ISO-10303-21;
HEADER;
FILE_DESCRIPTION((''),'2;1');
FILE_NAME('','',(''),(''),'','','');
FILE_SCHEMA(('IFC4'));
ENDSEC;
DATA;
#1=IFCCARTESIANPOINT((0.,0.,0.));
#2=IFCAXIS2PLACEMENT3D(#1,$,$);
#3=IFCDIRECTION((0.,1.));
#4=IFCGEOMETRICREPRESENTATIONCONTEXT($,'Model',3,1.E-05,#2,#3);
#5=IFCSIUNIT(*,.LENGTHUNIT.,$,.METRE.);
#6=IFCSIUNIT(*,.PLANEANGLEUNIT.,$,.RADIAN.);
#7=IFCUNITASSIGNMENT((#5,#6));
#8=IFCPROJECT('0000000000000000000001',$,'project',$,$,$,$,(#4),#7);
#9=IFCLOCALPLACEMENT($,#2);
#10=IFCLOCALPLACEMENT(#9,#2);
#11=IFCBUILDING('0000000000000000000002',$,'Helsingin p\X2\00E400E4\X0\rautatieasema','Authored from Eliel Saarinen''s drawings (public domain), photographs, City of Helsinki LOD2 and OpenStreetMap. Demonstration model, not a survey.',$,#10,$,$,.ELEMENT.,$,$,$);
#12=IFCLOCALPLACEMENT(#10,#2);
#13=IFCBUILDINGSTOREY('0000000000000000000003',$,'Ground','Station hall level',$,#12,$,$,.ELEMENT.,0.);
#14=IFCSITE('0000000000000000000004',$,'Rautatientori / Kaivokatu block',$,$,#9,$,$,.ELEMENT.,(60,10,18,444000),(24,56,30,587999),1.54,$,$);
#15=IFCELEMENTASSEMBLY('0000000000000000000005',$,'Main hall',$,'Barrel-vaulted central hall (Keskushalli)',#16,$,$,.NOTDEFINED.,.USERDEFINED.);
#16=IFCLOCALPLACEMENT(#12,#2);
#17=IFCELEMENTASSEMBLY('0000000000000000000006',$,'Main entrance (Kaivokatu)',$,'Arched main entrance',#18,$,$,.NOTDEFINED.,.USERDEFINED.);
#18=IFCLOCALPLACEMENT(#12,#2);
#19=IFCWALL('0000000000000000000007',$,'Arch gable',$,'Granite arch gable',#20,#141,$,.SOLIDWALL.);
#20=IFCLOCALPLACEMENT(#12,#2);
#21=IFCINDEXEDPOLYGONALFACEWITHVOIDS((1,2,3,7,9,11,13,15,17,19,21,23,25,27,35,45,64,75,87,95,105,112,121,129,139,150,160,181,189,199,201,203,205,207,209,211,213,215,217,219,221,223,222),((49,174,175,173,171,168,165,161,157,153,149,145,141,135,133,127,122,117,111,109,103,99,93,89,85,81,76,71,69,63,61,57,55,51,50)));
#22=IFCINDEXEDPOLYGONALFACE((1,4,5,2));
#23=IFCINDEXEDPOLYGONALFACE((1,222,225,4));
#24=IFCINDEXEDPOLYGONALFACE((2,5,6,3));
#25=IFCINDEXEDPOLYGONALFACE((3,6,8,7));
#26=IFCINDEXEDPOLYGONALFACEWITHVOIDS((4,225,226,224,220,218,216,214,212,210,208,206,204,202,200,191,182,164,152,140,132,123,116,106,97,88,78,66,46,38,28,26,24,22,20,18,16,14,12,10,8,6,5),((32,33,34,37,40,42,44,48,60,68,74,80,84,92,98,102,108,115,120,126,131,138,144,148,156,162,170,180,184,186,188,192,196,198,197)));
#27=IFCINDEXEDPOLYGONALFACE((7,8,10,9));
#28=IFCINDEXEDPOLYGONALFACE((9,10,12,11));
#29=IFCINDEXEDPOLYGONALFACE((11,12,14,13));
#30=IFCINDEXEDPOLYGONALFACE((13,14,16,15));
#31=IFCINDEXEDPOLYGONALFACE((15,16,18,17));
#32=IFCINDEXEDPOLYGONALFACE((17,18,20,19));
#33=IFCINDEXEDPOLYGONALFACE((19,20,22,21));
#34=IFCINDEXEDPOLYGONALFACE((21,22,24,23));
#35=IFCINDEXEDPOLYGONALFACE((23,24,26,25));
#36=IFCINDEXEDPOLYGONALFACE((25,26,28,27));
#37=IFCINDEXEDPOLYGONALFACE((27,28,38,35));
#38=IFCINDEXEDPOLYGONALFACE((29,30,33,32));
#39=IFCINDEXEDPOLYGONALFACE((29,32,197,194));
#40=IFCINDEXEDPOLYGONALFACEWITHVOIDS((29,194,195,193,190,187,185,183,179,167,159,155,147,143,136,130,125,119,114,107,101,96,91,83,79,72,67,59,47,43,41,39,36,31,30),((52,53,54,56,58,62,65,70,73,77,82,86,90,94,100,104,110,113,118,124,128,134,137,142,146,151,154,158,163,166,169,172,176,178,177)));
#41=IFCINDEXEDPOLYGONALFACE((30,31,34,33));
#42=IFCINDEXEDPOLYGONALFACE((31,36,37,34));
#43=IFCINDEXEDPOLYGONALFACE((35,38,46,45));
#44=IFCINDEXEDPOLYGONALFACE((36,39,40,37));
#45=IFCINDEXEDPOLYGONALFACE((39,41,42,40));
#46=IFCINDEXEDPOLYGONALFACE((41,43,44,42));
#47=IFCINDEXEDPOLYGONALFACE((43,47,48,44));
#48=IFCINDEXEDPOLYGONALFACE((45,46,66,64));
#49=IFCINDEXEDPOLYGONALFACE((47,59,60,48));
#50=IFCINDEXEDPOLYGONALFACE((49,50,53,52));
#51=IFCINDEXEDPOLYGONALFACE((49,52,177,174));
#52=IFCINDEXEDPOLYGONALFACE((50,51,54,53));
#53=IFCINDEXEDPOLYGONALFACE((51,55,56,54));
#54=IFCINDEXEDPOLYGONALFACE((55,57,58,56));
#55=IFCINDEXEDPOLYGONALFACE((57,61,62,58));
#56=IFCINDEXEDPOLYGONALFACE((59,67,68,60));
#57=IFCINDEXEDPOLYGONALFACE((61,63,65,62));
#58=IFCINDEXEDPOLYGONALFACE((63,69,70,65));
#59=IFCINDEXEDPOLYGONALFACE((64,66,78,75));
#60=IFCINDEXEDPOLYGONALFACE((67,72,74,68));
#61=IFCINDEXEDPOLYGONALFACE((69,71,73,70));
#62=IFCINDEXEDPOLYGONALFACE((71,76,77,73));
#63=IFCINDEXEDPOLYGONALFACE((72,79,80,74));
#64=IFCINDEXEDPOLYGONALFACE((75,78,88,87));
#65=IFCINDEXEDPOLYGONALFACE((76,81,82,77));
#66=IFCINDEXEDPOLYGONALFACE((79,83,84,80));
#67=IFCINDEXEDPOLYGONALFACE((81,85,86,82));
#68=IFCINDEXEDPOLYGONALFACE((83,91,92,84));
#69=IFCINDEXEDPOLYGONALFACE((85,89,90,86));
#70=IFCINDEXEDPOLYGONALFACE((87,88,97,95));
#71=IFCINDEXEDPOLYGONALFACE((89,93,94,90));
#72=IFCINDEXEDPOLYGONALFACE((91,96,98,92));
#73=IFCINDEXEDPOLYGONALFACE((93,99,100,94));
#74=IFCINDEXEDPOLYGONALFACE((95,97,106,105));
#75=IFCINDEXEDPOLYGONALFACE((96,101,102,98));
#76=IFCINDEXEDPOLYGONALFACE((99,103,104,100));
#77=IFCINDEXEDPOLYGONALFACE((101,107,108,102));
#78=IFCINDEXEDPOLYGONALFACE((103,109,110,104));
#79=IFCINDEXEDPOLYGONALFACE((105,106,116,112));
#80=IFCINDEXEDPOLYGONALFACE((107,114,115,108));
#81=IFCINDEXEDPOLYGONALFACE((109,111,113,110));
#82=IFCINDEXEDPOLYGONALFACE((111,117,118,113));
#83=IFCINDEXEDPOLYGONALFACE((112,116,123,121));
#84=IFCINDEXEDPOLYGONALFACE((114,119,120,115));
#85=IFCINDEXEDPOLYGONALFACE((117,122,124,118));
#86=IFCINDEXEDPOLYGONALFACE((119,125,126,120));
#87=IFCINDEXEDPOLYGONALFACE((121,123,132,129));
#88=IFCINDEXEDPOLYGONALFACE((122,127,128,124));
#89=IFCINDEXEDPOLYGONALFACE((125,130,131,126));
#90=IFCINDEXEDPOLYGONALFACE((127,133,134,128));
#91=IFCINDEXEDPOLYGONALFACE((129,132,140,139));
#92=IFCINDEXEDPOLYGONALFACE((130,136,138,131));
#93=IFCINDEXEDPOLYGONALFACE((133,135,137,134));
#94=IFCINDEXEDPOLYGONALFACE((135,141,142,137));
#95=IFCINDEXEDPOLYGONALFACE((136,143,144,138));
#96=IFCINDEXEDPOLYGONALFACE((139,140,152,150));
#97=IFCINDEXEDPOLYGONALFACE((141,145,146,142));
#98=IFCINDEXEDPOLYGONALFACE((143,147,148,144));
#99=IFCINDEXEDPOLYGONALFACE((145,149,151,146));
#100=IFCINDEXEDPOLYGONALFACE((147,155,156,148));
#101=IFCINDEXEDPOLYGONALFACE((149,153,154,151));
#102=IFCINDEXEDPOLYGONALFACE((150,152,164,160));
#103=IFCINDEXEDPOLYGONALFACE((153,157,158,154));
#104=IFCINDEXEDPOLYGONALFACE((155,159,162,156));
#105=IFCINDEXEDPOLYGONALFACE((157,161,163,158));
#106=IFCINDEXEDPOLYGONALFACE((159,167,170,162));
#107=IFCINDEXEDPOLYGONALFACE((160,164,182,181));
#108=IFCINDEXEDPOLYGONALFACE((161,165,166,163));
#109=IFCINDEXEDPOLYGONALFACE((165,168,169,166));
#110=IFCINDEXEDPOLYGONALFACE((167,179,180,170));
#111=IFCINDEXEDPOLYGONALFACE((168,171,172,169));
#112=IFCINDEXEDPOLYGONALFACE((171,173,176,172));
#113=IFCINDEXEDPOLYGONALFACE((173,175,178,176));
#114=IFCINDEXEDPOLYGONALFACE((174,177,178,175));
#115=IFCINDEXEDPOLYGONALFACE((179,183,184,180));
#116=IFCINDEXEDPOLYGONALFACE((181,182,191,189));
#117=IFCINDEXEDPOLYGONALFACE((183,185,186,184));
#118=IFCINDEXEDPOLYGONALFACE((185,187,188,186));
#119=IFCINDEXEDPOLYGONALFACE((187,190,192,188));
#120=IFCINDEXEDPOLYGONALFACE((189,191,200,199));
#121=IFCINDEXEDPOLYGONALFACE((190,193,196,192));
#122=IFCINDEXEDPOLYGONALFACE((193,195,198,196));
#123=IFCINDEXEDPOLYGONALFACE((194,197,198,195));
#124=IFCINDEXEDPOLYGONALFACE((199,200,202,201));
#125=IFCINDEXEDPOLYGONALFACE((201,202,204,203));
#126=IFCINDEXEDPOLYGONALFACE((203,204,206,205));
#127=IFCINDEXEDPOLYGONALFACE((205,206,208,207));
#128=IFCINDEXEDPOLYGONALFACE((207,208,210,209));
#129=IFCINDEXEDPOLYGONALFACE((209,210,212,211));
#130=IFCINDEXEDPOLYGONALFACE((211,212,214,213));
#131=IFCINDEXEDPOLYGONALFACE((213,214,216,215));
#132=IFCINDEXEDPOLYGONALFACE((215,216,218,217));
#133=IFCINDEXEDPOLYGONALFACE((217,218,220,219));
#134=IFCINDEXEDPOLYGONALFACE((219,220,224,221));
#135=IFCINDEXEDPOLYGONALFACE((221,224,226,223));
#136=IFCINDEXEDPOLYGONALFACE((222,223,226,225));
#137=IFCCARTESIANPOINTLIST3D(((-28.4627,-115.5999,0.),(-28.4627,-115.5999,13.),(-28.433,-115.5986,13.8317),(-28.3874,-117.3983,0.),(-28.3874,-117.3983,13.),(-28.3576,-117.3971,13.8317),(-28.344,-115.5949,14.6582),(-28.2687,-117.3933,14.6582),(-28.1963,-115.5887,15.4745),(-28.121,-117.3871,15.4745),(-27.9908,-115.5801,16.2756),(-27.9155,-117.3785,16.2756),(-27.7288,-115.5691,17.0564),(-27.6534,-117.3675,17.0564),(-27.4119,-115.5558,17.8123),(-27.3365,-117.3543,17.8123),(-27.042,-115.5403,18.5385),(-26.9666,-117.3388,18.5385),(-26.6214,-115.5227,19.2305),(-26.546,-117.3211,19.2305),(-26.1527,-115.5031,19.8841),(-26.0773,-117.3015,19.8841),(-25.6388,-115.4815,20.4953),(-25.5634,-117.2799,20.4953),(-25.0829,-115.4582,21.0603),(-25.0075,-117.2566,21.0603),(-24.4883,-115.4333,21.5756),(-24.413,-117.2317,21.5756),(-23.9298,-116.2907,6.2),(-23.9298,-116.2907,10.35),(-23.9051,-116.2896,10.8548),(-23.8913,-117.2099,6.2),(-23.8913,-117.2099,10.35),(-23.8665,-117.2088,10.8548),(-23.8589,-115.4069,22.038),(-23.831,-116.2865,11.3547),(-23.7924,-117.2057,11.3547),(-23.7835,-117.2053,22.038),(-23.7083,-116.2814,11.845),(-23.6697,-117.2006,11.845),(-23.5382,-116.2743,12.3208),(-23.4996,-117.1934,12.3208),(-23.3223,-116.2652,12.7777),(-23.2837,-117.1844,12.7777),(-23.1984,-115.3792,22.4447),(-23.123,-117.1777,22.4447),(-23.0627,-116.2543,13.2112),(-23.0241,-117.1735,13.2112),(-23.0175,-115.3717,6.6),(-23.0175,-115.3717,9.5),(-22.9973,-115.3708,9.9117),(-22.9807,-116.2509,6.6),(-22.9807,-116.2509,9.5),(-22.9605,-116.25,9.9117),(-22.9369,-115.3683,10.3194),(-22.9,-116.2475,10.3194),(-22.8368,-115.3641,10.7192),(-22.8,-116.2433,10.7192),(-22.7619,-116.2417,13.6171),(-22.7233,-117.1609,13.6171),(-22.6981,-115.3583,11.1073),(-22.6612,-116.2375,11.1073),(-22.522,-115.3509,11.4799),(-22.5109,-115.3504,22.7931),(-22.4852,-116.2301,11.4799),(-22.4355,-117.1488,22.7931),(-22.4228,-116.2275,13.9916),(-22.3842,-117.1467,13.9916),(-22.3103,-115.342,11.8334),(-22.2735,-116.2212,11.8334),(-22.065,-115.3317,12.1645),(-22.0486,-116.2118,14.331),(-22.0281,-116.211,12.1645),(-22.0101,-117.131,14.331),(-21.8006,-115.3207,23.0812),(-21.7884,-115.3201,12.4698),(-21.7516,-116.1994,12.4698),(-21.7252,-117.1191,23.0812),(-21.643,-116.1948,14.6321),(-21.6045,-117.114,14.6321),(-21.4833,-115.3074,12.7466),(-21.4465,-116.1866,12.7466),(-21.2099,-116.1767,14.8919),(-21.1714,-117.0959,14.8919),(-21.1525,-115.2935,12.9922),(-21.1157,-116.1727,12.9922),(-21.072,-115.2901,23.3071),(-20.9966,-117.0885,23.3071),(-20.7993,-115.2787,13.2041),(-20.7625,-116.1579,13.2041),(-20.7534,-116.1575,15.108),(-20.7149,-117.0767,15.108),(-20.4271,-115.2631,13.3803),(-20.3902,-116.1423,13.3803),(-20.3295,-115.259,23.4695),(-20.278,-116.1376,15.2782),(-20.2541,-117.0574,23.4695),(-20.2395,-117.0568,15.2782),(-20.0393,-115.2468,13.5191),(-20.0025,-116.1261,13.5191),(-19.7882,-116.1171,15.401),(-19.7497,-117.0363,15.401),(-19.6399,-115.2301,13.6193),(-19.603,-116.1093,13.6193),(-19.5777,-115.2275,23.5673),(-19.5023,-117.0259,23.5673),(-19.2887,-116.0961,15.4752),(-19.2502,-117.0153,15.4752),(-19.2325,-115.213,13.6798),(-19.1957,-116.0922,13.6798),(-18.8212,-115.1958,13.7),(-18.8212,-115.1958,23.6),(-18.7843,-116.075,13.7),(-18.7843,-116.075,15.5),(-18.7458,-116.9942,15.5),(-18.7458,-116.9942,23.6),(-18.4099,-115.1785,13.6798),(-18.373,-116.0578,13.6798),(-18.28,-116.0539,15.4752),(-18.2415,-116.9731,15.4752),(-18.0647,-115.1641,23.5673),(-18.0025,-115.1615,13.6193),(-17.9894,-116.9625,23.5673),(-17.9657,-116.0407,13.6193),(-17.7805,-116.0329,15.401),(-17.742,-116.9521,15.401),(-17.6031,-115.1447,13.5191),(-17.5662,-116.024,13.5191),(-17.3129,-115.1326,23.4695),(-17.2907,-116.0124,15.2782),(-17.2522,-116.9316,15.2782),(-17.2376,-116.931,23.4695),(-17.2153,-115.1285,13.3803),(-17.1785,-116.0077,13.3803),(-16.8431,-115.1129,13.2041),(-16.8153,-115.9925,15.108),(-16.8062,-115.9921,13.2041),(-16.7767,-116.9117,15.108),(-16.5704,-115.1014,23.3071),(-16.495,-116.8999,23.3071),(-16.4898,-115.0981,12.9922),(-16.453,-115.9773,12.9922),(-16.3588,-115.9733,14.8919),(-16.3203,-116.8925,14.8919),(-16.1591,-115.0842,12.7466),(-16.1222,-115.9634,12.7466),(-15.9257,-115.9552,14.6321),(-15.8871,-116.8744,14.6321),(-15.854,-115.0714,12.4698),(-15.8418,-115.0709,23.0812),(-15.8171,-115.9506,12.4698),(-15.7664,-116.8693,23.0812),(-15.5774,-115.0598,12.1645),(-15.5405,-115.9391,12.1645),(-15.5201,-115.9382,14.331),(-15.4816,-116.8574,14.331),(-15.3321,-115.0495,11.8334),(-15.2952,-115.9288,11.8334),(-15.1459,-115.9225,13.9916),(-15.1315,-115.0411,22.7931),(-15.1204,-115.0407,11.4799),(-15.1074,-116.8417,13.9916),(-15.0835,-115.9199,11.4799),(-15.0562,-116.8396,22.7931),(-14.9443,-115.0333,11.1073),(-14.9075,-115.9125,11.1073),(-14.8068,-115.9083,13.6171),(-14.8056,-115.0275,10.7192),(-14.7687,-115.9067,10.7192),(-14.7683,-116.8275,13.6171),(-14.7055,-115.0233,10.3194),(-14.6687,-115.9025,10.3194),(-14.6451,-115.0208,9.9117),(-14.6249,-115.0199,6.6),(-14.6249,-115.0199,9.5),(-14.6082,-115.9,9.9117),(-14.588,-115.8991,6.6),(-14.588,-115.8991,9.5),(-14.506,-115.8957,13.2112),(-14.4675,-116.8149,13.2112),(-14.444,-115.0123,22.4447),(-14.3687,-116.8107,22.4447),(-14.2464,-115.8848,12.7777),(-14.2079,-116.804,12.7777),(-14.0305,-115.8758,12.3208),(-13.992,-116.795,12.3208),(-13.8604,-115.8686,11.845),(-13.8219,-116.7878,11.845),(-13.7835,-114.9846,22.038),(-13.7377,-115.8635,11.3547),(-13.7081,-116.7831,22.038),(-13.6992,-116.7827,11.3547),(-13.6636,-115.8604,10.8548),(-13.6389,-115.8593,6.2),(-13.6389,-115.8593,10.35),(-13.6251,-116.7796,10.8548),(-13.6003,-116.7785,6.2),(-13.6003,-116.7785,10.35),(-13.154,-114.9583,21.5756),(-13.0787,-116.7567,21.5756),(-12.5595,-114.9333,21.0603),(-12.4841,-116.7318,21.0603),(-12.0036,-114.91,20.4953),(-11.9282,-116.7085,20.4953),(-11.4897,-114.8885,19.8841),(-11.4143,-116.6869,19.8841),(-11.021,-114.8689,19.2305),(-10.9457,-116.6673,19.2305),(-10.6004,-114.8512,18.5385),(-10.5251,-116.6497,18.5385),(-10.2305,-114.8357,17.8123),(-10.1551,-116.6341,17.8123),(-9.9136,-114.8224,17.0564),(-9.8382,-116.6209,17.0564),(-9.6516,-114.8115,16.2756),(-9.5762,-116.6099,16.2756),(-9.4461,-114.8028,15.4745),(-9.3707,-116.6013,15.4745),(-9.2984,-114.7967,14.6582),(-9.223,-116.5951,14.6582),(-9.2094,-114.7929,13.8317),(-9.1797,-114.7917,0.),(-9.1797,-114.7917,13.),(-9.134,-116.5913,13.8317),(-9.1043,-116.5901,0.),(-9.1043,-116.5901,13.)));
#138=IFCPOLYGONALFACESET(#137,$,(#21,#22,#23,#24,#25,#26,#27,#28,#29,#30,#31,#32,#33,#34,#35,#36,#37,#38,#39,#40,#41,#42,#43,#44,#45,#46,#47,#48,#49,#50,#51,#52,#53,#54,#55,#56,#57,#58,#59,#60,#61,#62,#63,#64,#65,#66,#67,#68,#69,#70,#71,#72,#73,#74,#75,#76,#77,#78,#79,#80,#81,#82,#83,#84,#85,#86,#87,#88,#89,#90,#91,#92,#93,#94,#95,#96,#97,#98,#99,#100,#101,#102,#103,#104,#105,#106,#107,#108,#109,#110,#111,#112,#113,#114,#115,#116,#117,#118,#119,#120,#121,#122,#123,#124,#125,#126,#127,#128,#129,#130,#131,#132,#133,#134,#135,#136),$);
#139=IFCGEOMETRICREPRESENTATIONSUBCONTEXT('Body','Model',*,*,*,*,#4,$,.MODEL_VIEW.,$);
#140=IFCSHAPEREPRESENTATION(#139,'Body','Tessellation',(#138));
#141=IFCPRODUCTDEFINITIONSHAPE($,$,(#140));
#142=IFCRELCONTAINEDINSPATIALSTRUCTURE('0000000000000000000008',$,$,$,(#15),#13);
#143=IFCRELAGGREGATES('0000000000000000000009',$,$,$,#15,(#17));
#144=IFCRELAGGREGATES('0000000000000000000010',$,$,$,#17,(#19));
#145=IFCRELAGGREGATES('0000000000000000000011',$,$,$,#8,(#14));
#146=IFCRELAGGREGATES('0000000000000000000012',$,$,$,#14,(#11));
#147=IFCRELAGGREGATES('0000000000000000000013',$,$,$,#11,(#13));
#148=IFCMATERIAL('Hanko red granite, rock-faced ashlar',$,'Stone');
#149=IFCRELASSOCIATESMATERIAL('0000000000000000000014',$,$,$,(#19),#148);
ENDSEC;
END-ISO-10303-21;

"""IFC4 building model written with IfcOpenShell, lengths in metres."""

from ifc_helpers import new_model, si_unit, direction, frame, origin, place, context, subcontext, project, spatial, polyline, outline, extrude, material, element, aggregate, save


model = new_model("IFC4")

# Units and contexts
model_context = context("Model", 3, precision=1e-05, world=origin(), true_north=direction((0.0, 1.0)))
body_context = subcontext(model_context, "Body", "Model", "MODEL_VIEW")
ifc_project = project(units=[si_unit("LENGTHUNIT", "METRE"), si_unit("PLANEANGLEUNIT", "RADIAN")], contexts=[model_context])

# Site, building, storey
site_placement = place(None, origin())
site = spatial("IfcSite", under=ifc_project, at=site_placement, Name="Rautatientori / Kaivokatu block", CompositionType="ELEMENT", RefLatitude=(60, 10, 18, 444000), RefLongitude=(24, 56, 30, 587999), RefElevation=1.54)
building_placement = place(site_placement, origin())
building = spatial("IfcBuilding", under=site, at=building_placement, Name="Helsingin päärautatieasema", Description="Authored from Eliel Saarinen's drawings (public domain), photographs, City of Helsinki LOD2 and OpenStreetMap. Demonstration model, not a survey.", CompositionType="ELEMENT")
storey_placement = place(building_placement, origin())
storey = spatial("IfcBuildingStorey", under=building, at=storey_placement, Name="Ground", Description="Station hall level", CompositionType="ELEMENT", Elevation=0.0)

# Element assemblies, wall, openings
assembly_1_placement = place(building_placement, origin())
assembly_1 = element("IfcElementAssembly", 1, at=assembly_1_placement, inside=storey, Name="Main hall", ObjectType="Barrel-vaulted central hall (Keskushalli)", AssemblyPlace="NOTDEFINED", PredefinedType="USERDEFINED")
assembly_2_placement = place(building_placement, origin())
assembly_2 = element("IfcElementAssembly", 2, at=assembly_2_placement, Name="Main entrance (Kaivokatu)", ObjectType="Arched main entrance", AssemblyPlace="NOTDEFINED", PredefinedType="USERDEFINED")
ifc_material_1 = material(Name="Hanko red granite, rock-faced ashlar", Category="Stone")
wall_1_placement = place(building_placement, origin())
wall_1 = element("IfcWall", 3, at=wall_1_placement, material=ifc_material_1, Name="Arch gable", ObjectType="Granite arch gable", PredefinedType="SOLIDWALL", context=body_context, shape_type="SweptSolid", body=[
    extrude(outline(polyline([(-9.65, 0.0), (9.65, 0.0), (9.65, 13.0), (9.6203, 13.8317), (9.5312, 14.6582), (9.3834, 15.4745), (9.1777, 16.2756), (8.9154, 17.0564), (8.5982, 17.8123), (8.228, 18.5385), (7.807, 19.2305), (7.3379, 19.8841), (6.8236, 20.4953), (6.2672, 21.0603), (5.6721, 21.5756), (5.0421, 22.038), (4.381, 22.4447), (3.6929, 22.7931), (2.982, 23.0812), (2.2527, 23.3071), (1.5096, 23.4695), (0.7571, 23.5673), (0.0, 23.6), (-0.7571, 23.5673), (-1.5096, 23.4695), (-2.2527, 23.3071), (-2.982, 23.0812), (-3.6929, 22.7931), (-4.381, 22.4447), (-5.0421, 22.038), (-5.6721, 21.5756), (-6.2672, 21.0603), (-6.8236, 20.4953), (-7.3379, 19.8841), (-7.807, 19.2305), (-8.228, 18.5385), (-8.5982, 17.8123), (-8.9154, 17.0564), (-9.1777, 16.2756), (-9.3834, 15.4745), (-9.5312, 14.6582), (-9.6203, 13.8317), (-9.65, 13.0), (-9.65, 0.0)])), frame((-18.8212, -115.1958, 0.0), z_axis=(0.041876, -0.999123, 0.0), x_axis=(0.999123, 0.041876, 0.0)), (0.0, 0.0, 1.0), 1.8),
])
opening_1_placement = place(building_placement, origin())
element("IfcOpeningElement", 4, at=opening_1_placement, cuts=wall_1, PredefinedType="OPENING", context=body_context, shape_type="SweptSolid", body=[
    extrude(outline(polyline([(-5.15, 6.2), (5.15, 6.2), (5.15, 10.35), (5.1252, 10.8548), (5.051, 11.3547), (4.9282, 11.845), (4.758, 12.3208), (4.5419, 12.7777), (4.2821, 13.2112), (3.981, 13.6171), (3.6416, 13.9916), (3.2671, 14.331), (2.8612, 14.6321), (2.4277, 14.8919), (1.9708, 15.108), (1.495, 15.2782), (1.0047, 15.401), (0.5048, 15.4752), (0.0, 15.5), (-0.5048, 15.4752), (-1.0047, 15.401), (-1.495, 15.2782), (-1.9708, 15.108), (-2.4277, 14.8919), (-2.8612, 14.6321), (-3.2671, 14.331), (-3.6416, 13.9916), (-3.981, 13.6171), (-4.2821, 13.2112), (-4.5419, 12.7777), (-4.758, 12.3208), (-4.9282, 11.845), (-5.051, 11.3547), (-5.1252, 10.8548), (-5.15, 10.35), (-5.15, 6.2)])), frame((-18.7843, -116.075, 0.0), z_axis=(0.041876, -0.999123, 0.0), x_axis=(0.999123, 0.041876, 0.0)), (0.0, 0.0, 1.0), 0.92),
])
opening_2_placement = place(building_placement, origin())
element("IfcOpeningElement", 5, at=opening_2_placement, cuts=wall_1, PredefinedType="OPENING", context=body_context, shape_type="SweptSolid", body=[
    extrude(outline(polyline([(-4.2, 6.6), (4.2, 6.6), (4.2, 9.5), (4.1798, 9.9117), (4.1193, 10.3194), (4.0191, 10.7192), (3.8803, 11.1073), (3.7041, 11.4799), (3.4922, 11.8334), (3.2466, 12.1645), (2.9698, 12.4698), (2.6645, 12.7466), (2.3334, 12.9922), (1.9799, 13.2041), (1.6073, 13.3803), (1.2192, 13.5191), (0.8194, 13.6193), (0.4117, 13.6798), (0.0, 13.7), (-0.4117, 13.6798), (-0.8194, 13.6193), (-1.2192, 13.5191), (-1.6073, 13.3803), (-1.9799, 13.2041), (-2.3334, 12.9922), (-2.6645, 12.7466), (-2.9698, 12.4698), (-3.2466, 12.1645), (-3.4922, 11.8334), (-3.7041, 11.4799), (-3.8803, 11.1073), (-4.0191, 10.7192), (-4.1193, 10.3194), (-4.1798, 9.9117), (-4.2, 9.5), (-4.2, 6.6)])), frame((-18.8258, -115.0859, 0.0), z_axis=(0.041876, -0.999123, 0.0), x_axis=(0.999123, 0.041876, 0.0)), (0.0, 0.0, 1.0), 2.0),
])
aggregate(assembly_1, [assembly_2])
aggregate(assembly_2, [wall_1])

save(model, "model.ifc")
